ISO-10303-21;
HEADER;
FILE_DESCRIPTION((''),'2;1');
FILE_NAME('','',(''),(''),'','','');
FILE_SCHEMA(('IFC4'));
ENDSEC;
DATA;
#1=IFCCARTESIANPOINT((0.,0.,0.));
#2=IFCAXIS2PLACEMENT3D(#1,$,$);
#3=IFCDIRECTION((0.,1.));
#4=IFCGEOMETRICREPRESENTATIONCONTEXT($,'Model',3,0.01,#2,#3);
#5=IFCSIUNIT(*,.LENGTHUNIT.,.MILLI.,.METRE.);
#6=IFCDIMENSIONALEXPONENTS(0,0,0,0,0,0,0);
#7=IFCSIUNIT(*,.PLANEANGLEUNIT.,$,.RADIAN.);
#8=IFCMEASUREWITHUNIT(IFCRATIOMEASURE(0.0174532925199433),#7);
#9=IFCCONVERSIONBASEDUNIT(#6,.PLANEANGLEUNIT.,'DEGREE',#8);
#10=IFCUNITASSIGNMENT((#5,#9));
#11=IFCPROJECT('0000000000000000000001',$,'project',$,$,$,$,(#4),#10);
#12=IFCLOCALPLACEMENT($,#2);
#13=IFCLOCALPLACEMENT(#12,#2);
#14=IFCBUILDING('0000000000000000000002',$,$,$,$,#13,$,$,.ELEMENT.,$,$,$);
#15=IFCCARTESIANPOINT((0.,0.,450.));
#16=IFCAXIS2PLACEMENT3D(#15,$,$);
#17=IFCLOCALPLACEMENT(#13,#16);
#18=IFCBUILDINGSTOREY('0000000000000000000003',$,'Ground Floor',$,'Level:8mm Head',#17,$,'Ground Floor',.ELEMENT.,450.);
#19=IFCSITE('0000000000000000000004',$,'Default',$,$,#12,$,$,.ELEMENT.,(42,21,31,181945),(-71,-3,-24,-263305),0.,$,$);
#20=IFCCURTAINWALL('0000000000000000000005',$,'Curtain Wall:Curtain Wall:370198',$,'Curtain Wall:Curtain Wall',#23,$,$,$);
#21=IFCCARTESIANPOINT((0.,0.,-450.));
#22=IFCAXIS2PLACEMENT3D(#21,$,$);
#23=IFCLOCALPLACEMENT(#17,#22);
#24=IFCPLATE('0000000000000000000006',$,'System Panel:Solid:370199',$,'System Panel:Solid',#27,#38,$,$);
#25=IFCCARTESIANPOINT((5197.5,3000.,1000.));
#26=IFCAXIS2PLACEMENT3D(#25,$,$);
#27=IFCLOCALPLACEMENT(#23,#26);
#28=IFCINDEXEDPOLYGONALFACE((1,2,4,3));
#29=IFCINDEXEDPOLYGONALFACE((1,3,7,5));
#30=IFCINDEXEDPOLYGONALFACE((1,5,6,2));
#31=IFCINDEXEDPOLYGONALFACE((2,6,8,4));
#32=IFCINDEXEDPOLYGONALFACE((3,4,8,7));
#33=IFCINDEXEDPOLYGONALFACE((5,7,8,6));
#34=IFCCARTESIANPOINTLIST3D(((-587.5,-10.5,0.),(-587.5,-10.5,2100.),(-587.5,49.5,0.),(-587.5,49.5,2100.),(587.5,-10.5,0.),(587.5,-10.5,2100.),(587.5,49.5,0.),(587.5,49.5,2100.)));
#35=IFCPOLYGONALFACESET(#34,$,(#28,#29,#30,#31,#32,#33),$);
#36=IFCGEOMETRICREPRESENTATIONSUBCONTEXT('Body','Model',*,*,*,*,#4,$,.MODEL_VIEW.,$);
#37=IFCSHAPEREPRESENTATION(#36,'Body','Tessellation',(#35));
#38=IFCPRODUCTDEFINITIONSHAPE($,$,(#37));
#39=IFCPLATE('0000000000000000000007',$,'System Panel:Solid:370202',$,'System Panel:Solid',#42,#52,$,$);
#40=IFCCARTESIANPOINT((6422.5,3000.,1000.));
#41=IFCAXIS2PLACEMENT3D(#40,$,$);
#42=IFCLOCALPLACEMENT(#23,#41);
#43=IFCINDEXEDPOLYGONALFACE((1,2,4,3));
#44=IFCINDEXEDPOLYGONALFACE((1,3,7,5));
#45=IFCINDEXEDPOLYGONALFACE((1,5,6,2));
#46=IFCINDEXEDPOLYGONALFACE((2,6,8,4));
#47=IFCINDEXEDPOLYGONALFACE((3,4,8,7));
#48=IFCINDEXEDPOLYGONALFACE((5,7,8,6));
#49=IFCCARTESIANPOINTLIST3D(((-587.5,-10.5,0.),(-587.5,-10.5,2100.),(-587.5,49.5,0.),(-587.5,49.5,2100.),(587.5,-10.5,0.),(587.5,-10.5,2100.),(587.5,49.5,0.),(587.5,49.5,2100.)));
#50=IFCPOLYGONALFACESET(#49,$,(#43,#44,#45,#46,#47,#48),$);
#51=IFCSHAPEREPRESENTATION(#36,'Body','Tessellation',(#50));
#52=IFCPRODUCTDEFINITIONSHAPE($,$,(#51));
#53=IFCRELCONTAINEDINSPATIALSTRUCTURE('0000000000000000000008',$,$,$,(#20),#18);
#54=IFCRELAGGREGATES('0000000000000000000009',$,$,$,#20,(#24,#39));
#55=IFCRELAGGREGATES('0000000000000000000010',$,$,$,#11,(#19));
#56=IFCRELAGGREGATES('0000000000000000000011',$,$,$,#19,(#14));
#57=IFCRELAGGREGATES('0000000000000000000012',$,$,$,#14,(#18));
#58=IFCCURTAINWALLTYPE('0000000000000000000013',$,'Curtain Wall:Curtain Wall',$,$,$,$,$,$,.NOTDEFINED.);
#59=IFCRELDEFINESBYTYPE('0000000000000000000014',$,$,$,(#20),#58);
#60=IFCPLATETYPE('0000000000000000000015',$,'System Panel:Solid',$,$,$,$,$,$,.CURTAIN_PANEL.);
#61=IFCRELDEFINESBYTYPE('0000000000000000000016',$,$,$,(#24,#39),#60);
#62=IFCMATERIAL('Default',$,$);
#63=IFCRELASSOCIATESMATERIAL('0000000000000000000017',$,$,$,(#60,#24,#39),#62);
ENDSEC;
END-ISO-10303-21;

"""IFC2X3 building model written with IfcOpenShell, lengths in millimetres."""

from ifc_helpers import new_model, entity, si_unit, converted_unit, direction, frame, origin, origin_2d_with_axis, place, context, subcontext, project, spatial, rectangle, extrude, source, transform, mapped, material, type_object, type_shapes, element, aggregate, save


model = new_model("IFC2X3")

# Units and contexts
model_context = context("Model", 3, precision=0.01, world=origin(), true_north=direction((0.0, 1.0)))
body_context = subcontext(model_context, "Body", "Model", "MODEL_VIEW")
ifc_project = project(units=[si_unit("LENGTHUNIT", "METRE", prefix="MILLI"), converted_unit("PLANEANGLEUNIT", "DEGREE", entity("IfcRatioMeasure", 0.0174532925199433), si_unit("PLANEANGLEUNIT", "RADIAN"), dimensions=[0, 0, 0, 0, 0, 0, 0])], contexts=[model_context])

# Site, building, storey
site_placement = place(None, origin())
site = spatial("IfcSite", under=ifc_project, at=site_placement, Name="Default", CompositionType="ELEMENT", RefLatitude=(42, 21, 31, 181945), RefLongitude=(-71, -3, -24, -263305), RefElevation=0.0)
building_placement = place(site_placement, origin())
building = spatial("IfcBuilding", under=site, at=building_placement, CompositionType="ELEMENT")
storey_placement = place(building_placement, frame((0.0, 0.0, 450.0)))
storey = spatial("IfcBuildingStorey", under=building, at=storey_placement, Name="Ground Floor", ObjectType="Level:8mm Head", LongName="Ground Floor", CompositionType="ELEMENT", Elevation=450.0)

# Curtain wall
curtain_wall_type = type_object("IfcCurtainWallType", Name="Curtain Wall:Curtain Wall", PredefinedType="NOTDEFINED")
curtain_wall_placement = place(storey_placement, frame((0.0, 0.0, -450.0)))
curtain_wall = element("IfcCurtainWall", 1, at=curtain_wall_placement, inside=storey, type_object=curtain_wall_type, Name="Curtain Wall:Curtain Wall:370198", ObjectType="Curtain Wall:Curtain Wall")

# Plates
ifc_material_1 = material(Name="Default")
plate_type = type_object("IfcPlateType", Name="System Panel:Solid", PredefinedType="CURTAIN_PANEL", material=ifc_material_1)
shared_shape_1 = source(origin(), body_context, "Body", "SweptSolid", [
    extrude(rectangle(XDim=60.0, YDim=1175.0, at=origin_2d_with_axis()), frame((0.0, 19.5, 0.0), z_axis=(0.0, 0.0, 1.0), x_axis=(0.0, 1.0, 0.0)), (0.0, 0.0, 1.0), 2100.0),
])
type_shapes(plate_type, [shared_shape_1])
plate_1_placement = place(curtain_wall_placement, frame((5197.5, 3000.0, 1000.0)))
plate_1 = element("IfcPlate", 2, at=plate_1_placement, type_object=plate_type, material=ifc_material_1, Name="System Panel:Solid:370199", ObjectType="System Panel:Solid", context=body_context, shape_type="MappedRepresentation", body=[
    mapped(shared_shape_1, transform((0.0, 0.0, 0.0), scale=1.0)),
])
plate_2_placement = place(curtain_wall_placement, frame((6422.5, 3000.0, 1000.0)))
plate_2 = element("IfcPlate", 3, at=plate_2_placement, type_object=plate_type, material=ifc_material_1, Name="System Panel:Solid:370202", ObjectType="System Panel:Solid", context=body_context, shape_type="MappedRepresentation", body=[
    mapped(shared_shape_1, transform((0.0, 0.0, 0.0), scale=1.0)),
])
aggregate(curtain_wall, [plate_1, plate_2])

save(model, "model.ifc")
